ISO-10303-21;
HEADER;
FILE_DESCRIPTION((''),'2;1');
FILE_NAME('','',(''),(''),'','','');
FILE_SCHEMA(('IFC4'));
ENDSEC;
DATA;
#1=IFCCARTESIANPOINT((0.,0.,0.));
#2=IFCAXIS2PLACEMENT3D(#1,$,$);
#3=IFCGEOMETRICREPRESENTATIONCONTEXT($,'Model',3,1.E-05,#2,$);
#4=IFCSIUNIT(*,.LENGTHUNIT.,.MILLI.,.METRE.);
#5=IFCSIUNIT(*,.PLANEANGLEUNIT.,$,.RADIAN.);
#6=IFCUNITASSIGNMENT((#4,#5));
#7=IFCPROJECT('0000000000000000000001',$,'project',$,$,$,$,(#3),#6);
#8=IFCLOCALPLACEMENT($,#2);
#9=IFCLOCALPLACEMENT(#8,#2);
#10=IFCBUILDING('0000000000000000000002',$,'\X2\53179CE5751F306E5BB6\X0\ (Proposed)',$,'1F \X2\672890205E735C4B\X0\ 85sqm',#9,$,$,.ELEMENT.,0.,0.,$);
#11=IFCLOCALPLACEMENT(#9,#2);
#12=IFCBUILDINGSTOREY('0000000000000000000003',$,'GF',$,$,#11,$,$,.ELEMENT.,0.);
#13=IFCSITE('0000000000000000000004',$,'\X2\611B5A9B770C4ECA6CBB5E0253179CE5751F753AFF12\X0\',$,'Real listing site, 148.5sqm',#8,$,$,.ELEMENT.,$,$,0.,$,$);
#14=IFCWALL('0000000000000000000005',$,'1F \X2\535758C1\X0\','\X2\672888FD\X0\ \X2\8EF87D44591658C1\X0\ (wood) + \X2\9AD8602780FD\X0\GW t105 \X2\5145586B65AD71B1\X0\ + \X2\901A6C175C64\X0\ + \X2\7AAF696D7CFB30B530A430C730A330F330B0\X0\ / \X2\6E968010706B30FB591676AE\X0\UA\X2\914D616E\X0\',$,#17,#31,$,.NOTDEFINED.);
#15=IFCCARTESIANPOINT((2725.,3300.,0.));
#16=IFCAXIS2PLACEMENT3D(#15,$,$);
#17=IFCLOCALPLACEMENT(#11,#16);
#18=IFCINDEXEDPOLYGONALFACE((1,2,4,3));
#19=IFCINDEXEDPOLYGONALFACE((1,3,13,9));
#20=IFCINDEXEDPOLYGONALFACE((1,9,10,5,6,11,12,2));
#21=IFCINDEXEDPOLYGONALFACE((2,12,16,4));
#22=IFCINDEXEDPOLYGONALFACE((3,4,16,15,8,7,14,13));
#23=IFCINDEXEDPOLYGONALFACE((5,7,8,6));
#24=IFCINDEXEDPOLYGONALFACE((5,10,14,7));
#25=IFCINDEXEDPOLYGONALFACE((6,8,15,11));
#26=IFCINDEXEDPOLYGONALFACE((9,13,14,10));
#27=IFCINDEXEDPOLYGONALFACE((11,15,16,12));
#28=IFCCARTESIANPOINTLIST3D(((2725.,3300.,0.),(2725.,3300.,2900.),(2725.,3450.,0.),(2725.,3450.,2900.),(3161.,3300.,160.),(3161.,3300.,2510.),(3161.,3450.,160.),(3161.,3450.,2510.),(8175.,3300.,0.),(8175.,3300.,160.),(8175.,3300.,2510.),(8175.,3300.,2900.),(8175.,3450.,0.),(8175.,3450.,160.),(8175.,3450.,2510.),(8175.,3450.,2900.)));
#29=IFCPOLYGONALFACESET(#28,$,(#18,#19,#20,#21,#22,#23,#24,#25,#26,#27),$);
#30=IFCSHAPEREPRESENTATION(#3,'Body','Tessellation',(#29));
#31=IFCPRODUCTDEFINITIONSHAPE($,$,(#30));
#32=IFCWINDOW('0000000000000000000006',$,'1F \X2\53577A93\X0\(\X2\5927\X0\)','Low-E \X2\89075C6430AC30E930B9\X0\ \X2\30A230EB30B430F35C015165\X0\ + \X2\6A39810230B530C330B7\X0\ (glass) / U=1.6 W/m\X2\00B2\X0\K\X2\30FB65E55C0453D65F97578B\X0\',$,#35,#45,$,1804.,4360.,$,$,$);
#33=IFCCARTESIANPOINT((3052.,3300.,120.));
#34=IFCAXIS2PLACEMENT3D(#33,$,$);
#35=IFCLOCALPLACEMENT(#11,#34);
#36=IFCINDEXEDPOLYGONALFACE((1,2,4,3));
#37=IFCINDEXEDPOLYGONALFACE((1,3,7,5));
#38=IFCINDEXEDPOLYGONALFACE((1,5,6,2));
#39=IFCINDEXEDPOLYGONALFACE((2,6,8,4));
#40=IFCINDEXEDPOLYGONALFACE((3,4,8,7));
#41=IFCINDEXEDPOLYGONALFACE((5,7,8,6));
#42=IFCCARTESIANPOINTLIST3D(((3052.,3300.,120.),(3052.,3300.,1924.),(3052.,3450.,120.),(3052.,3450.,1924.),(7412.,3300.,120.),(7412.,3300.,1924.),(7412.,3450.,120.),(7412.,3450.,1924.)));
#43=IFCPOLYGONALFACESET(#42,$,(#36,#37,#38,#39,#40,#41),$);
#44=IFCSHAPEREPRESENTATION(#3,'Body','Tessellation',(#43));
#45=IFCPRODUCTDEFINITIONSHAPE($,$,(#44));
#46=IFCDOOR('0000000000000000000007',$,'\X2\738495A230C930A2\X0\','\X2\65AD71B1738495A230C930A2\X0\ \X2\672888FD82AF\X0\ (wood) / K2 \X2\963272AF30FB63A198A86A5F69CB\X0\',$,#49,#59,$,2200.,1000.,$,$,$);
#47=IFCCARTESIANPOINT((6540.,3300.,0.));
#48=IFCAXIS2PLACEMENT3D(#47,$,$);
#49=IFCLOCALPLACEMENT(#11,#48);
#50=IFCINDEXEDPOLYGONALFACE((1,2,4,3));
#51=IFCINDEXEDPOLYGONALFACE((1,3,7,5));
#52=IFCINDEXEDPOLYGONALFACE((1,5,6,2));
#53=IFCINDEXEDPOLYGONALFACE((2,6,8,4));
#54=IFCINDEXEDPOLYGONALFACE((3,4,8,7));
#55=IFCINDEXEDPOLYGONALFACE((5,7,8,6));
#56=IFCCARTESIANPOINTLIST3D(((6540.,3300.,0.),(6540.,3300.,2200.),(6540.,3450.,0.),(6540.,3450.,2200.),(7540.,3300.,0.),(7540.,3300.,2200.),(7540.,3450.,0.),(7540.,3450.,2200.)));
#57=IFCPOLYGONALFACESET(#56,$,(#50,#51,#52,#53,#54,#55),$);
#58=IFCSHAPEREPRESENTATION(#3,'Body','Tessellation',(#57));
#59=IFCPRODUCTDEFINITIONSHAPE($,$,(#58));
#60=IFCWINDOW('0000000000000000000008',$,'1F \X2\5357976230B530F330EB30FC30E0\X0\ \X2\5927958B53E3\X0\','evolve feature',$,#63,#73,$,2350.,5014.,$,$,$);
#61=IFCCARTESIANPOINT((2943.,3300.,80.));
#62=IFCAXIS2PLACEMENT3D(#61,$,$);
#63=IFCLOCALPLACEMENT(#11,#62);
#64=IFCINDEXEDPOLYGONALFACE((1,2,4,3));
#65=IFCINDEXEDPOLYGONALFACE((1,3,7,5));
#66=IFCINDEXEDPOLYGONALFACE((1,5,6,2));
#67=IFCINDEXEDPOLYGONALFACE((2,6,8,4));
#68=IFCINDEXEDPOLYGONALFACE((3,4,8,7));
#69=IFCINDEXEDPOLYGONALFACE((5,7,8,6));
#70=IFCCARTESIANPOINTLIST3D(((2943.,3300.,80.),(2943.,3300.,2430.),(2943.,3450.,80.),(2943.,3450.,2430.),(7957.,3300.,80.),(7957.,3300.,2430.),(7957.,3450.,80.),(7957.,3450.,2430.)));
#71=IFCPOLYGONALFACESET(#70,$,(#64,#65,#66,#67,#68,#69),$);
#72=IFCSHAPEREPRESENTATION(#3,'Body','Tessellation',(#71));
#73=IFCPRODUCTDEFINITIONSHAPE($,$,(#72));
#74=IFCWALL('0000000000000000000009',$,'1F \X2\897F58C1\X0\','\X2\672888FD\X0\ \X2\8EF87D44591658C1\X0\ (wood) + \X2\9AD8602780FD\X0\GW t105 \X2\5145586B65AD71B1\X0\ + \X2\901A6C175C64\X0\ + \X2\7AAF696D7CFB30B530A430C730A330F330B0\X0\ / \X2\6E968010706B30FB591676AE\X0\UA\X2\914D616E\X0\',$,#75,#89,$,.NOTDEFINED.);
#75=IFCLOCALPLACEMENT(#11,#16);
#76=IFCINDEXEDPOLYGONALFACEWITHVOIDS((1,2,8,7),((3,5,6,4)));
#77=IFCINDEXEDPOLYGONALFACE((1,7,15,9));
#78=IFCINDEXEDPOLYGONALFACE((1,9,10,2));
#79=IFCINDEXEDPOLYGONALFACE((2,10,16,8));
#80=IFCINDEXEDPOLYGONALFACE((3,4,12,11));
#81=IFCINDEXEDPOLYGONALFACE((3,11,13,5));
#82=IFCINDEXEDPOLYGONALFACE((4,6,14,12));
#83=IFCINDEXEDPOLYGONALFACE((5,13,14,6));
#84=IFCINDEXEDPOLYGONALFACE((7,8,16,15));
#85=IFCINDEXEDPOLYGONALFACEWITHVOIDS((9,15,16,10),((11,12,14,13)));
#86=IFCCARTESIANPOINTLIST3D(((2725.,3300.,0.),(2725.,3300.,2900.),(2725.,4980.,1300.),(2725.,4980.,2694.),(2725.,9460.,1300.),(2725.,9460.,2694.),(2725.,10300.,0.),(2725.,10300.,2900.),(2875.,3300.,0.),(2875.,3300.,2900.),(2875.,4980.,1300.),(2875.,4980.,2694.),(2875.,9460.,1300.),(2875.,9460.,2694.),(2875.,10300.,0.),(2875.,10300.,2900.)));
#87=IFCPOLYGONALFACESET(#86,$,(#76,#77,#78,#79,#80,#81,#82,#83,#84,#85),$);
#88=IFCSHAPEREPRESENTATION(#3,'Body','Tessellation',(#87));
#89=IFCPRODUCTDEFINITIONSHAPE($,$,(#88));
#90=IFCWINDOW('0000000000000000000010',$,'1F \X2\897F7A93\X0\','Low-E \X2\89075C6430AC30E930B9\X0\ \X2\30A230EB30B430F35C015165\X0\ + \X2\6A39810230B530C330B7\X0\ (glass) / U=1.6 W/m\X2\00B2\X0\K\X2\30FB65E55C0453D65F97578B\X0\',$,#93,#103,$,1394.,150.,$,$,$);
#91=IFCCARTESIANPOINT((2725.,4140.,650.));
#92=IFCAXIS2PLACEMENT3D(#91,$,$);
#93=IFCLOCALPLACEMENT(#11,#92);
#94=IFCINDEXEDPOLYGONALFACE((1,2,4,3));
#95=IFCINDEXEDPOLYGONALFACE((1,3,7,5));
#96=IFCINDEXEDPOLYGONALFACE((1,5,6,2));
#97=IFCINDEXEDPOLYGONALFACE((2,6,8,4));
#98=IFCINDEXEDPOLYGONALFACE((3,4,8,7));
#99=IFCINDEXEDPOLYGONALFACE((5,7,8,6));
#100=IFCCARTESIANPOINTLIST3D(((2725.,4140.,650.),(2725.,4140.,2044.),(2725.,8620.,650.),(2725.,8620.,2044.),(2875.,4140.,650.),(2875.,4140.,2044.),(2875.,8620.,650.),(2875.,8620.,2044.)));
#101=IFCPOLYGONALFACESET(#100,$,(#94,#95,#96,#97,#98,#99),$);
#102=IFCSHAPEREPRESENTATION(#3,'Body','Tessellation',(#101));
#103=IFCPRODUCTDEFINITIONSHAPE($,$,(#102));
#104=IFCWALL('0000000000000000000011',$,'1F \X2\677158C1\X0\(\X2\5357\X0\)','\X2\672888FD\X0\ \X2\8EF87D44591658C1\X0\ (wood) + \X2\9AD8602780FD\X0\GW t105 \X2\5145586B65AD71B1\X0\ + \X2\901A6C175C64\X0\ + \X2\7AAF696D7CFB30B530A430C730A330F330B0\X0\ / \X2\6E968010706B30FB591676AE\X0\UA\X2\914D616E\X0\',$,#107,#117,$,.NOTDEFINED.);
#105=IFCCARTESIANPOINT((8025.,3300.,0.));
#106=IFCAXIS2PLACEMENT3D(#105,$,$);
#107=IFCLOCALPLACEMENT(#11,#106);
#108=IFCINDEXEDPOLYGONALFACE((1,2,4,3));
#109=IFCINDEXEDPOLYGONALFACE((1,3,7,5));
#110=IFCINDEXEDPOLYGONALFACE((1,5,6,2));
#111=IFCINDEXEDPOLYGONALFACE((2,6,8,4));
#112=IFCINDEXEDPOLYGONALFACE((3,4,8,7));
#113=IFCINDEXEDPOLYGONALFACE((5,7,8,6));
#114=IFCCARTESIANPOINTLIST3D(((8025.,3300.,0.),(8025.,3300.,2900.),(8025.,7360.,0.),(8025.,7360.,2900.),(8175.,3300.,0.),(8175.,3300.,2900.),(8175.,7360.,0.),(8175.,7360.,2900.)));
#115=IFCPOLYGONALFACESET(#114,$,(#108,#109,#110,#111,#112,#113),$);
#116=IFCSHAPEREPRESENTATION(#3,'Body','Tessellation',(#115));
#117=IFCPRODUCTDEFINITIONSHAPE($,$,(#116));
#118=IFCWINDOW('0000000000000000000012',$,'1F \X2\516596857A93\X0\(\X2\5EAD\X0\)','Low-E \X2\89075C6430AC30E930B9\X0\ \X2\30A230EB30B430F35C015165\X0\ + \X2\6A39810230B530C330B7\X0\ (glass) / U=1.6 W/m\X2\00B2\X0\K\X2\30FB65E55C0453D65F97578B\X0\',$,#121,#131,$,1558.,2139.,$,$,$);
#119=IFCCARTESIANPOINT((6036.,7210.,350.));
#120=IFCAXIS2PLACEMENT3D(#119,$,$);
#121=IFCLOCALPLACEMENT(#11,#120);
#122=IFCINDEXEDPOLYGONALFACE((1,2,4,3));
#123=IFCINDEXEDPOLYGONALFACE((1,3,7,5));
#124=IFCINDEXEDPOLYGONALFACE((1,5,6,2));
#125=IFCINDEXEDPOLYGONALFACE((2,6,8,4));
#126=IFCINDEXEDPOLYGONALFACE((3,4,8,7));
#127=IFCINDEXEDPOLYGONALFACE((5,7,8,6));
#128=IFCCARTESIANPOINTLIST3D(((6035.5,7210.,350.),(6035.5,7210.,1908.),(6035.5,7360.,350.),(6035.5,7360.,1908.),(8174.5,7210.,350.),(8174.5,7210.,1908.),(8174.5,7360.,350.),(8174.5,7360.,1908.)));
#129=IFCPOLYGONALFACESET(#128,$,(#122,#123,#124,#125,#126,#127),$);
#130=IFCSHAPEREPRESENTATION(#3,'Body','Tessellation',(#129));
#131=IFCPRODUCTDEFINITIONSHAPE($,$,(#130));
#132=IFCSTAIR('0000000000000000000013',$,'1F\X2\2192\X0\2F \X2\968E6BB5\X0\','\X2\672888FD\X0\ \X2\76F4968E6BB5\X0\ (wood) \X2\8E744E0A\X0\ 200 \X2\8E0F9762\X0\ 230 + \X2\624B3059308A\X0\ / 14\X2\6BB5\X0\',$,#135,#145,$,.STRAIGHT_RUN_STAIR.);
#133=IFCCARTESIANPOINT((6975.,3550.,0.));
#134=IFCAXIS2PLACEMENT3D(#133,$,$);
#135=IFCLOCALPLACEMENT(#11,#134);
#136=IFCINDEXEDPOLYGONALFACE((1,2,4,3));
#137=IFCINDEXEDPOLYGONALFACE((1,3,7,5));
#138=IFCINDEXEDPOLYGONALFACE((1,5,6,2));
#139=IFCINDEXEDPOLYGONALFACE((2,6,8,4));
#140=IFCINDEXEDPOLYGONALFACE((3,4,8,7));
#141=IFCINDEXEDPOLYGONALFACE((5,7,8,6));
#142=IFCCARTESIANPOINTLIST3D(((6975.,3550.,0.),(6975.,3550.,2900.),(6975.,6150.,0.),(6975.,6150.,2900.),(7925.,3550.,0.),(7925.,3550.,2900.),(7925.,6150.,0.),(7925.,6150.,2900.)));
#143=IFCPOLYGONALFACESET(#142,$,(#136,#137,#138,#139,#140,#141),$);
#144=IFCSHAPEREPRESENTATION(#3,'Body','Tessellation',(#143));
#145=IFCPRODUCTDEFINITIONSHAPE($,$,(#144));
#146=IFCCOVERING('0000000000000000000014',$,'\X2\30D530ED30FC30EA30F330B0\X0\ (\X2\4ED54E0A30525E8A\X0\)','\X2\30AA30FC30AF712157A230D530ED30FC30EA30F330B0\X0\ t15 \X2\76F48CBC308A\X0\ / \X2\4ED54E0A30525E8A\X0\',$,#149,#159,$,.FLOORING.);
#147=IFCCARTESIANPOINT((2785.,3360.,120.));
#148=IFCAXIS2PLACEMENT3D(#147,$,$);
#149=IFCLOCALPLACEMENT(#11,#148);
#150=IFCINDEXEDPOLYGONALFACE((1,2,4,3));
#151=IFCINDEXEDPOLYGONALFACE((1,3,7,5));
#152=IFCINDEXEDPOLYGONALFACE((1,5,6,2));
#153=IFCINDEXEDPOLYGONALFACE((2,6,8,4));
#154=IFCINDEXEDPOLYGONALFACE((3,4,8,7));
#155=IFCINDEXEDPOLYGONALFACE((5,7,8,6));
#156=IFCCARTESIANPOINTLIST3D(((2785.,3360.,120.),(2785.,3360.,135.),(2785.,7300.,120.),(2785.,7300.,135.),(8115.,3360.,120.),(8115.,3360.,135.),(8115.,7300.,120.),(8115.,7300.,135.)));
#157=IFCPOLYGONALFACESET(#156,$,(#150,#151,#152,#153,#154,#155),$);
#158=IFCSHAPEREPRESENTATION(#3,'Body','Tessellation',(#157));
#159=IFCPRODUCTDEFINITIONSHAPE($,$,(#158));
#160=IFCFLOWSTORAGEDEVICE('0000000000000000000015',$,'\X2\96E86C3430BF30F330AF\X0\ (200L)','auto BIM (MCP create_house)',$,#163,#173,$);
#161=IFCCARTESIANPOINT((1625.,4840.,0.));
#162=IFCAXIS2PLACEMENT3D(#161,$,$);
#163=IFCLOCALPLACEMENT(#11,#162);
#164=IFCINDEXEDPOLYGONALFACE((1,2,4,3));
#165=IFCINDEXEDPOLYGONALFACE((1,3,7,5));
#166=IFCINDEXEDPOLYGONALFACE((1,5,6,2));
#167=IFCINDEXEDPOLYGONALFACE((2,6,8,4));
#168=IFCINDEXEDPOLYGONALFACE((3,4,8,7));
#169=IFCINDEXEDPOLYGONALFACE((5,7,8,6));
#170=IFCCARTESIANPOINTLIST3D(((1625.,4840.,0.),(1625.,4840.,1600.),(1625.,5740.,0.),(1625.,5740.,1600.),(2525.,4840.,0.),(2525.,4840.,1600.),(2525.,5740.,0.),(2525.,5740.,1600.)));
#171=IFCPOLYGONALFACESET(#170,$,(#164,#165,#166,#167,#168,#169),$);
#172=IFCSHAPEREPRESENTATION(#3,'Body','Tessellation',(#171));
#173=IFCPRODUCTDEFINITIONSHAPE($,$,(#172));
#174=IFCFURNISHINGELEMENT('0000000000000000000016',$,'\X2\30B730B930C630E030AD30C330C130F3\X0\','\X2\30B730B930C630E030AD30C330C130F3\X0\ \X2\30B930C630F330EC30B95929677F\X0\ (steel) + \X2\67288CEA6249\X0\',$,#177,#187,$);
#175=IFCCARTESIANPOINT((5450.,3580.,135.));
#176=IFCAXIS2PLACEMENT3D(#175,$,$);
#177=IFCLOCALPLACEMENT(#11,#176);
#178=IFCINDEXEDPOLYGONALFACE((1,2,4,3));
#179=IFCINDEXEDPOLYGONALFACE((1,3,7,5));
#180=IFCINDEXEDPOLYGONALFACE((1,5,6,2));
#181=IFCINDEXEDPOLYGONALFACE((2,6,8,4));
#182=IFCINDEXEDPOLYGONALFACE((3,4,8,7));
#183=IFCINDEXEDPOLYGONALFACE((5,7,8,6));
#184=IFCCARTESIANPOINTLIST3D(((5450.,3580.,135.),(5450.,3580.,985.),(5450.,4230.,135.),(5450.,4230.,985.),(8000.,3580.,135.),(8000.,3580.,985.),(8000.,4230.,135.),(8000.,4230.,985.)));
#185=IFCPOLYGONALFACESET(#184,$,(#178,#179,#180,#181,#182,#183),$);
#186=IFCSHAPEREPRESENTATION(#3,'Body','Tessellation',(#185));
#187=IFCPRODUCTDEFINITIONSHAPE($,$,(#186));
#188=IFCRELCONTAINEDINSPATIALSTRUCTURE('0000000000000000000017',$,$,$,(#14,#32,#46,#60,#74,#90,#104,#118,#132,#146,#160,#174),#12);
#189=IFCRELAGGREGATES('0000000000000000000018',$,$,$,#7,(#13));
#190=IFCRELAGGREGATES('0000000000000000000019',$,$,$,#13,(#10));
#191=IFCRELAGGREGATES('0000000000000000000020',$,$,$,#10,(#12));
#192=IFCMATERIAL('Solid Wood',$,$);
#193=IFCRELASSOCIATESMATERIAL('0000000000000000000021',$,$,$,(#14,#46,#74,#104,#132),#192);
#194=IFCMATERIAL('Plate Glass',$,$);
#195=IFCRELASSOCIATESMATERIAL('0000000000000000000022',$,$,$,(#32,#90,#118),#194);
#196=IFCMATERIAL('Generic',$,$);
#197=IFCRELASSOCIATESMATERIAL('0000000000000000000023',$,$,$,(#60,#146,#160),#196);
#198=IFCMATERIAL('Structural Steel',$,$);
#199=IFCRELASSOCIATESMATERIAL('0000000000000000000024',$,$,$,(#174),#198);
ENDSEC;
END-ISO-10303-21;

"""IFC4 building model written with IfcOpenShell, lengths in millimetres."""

from ifc_helpers import new_model, si_unit, frame, frame_2d, origin, place, context, project, spatial, rectangle, extrude, material, element, fill, save


model = new_model("IFC4")

# Units and contexts
model_context = context("Model", 3, precision=1e-05, world=origin())
ifc_project = project(units=[si_unit("LENGTHUNIT", "METRE", prefix="MILLI"), si_unit("PLANEANGLEUNIT", "RADIAN")], contexts=[model_context])

# Site, building, storey
site_placement = place(None, origin())
site = spatial("IfcSite", under=ifc_project, at=site_placement, Name="愛媛県今治市北鳥生町２", ObjectType="Real listing site, 148.5sqm", CompositionType="ELEMENT", RefElevation=0.0)
building_placement = place(site_placement, origin())
building = spatial("IfcBuilding", under=site, at=building_placement, Name="北鳥生の家 (Proposed)", ObjectType="1F 木造平屋 85sqm", CompositionType="ELEMENT", ElevationOfRefHeight=0.0, ElevationOfTerrain=0.0)
storey_placement = place(building_placement, origin())
storey = spatial("IfcBuildingStorey", under=building, at=storey_placement, Name="GF", CompositionType="ELEMENT", Elevation=0.0)

# Shared definitions
ifc_material_1 = material(Name="Solid Wood")
ifc_material_2 = material(Name="Generic")

# Wall, openings, windows, door
wall_1_placement = place(storey_placement, frame((2725.0, 3300.0, 0.0)))
wall_1 = element("IfcWall", 1, at=wall_1_placement, inside=storey, material=ifc_material_1, Name="1F 南壁", Description="木製 軸組外壁 (wood) + 高性能GW t105 充填断熱 + 通気層 + 窯業系サイディング / 準耐火・外皮UA配慮", PredefinedType="NOTDEFINED", context=model_context, shape_type="SweptSolid", body=[
    extrude(rectangle(XDim=5450.0, YDim=150.0, at=frame_2d((2725.0, 75.0))), frame((2725.0, 3300.0, 0.0)), (0.0, 0.0, 1.0), 2900.0),
])
opening_1_placement = place(storey_placement, frame((3052.0, 3300.0, 120.0)))
opening_1 = element("IfcOpeningElement", 2, at=opening_1_placement, cuts=wall_1, PredefinedType="NOTDEFINED", context=model_context, shape_type="SweptSolid", body=[
    extrude(rectangle(XDim=4360.0, YDim=150.0, at=frame_2d((2180.0, 75.0))), frame((3052.0, 3300.0, 120.0)), (0.0, 0.0, 1.0), 1804.0),
])
opening_2_placement = place(storey_placement, frame((6540.0, 3300.0, 0.0)))
opening_2 = element("IfcOpeningElement", 3, at=opening_2_placement, cuts=wall_1, PredefinedType="NOTDEFINED", context=model_context, shape_type="SweptSolid", body=[
    extrude(rectangle(XDim=1000.0, YDim=150.0, at=frame_2d((500.0, 75.0))), frame((6540.0, 3300.0, 0.0)), (0.0, 0.0, 1.0), 2200.0),
])
opening_3_placement = place(storey_placement, frame((2943.0, 3300.0, 80.0)))
opening_3 = element("IfcOpeningElement", 4, at=opening_3_placement, cuts=wall_1, PredefinedType="NOTDEFINED", context=model_context, shape_type="SweptSolid", body=[
    extrude(rectangle(XDim=5014.0, YDim=150.0, at=frame_2d((2507.0, 75.0))), frame((2943.0, 3300.0, 80.0)), (0.0, 0.0, 1.0), 2350.0),
])
ifc_material_3 = material(Name="Plate Glass")
window_1_placement = place(storey_placement, frame((3052.0, 3300.0, 120.0)))
window_1 = element("IfcWindow", 5, at=window_1_placement, inside=storey, material=ifc_material_3, Name="1F 南窓(大)", Description="Low-E 複層ガラス アルゴン封入 + 樹脂サッシ (glass) / U=1.6 W/m²K・日射取得型", OverallHeight=1804.0, OverallWidth=4360.0, context=model_context, shape_type="SweptSolid", body=[
    extrude(rectangle(XDim=4360.0, YDim=150.0, at=frame_2d((2180.0, 75.0))), frame((3052.0, 3300.0, 120.0)), (0.0, 0.0, 1.0), 1804.0),
])
fill(opening_1, window_1)
door_1_placement = place(storey_placement, frame((6540.0, 3300.0, 0.0)))
door_1 = element("IfcDoor", 6, at=door_1_placement, inside=storey, material=ifc_material_1, Name="玄関ドア", Description="断熱玄関ドア 木製芯 (wood) / K2 防犯・採風機構", OverallHeight=2200.0, OverallWidth=1000.0, context=model_context, shape_type="SweptSolid", body=[
    extrude(rectangle(XDim=1000.0, YDim=150.0, at=frame_2d((500.0, 75.0))), frame((6540.0, 3300.0, 0.0)), (0.0, 0.0, 1.0), 2200.0),
])
fill(opening_2, door_1)
window_2_placement = place(storey_placement, frame((2943.0, 3300.0, 80.0)))
window_2 = element("IfcWindow", 7, at=window_2_placement, inside=storey, material=ifc_material_2, Name="1F 南面サンルーム 大開口", Description="evolve feature", OverallHeight=2350.0, OverallWidth=5014.0, context=model_context, shape_type="SweptSolid", body=[
    extrude(rectangle(XDim=5014.0, YDim=150.0, at=frame_2d((2507.0, 75.0))), frame((2943.0, 3300.0, 80.0)), (0.0, 0.0, 1.0), 2350.0),
])
fill(opening_3, window_2)

# Walls, openings, windows
wall_2_placement = place(storey_placement, frame((2725.0, 3300.0, 0.0)))
wall_2 = element("IfcWall", 8, at=wall_2_placement, inside=storey, material=ifc_material_1, Name="1F 西壁", Description="木製 軸組外壁 (wood) + 高性能GW t105 充填断熱 + 通気層 + 窯業系サイディング / 準耐火・外皮UA配慮", PredefinedType="NOTDEFINED", context=model_context, shape_type="SweptSolid", body=[
    extrude(rectangle(XDim=150.0, YDim=7000.0, at=frame_2d((75.0, 3500.0))), frame((2725.0, 3300.0, 0.0)), (0.0, 0.0, 1.0), 2900.0),
])
opening_4_placement = place(storey_placement, frame((2725.0, 4140.0, 650.0)))
opening_4 = element("IfcOpeningElement", 9, at=opening_4_placement, cuts=wall_2, PredefinedType="NOTDEFINED", context=model_context, shape_type="SweptSolid", body=[
    extrude(rectangle(XDim=150.0, YDim=4480.0, at=frame_2d((75.0, 2240.0))), frame((2725.0, 4140.0, 650.0)), (0.0, 0.0, 1.0), 1394.0),
])
window_3_placement = place(storey_placement, frame((2725.0, 4140.0, 650.0)))
window_3 = element("IfcWindow", 10, at=window_3_placement, inside=storey, material=ifc_material_3, Name="1F 西窓", Description="Low-E 複層ガラス アルゴン封入 + 樹脂サッシ (glass) / U=1.6 W/m²K・日射取得型", OverallHeight=1394.0, OverallWidth=150.0, context=model_context, shape_type="SweptSolid", body=[
    extrude(rectangle(XDim=150.0, YDim=4480.0, at=frame_2d((75.0, 2240.0))), frame((2725.0, 4140.0, 650.0)), (0.0, 0.0, 1.0), 1394.0),
])
fill(opening_4, window_3)
wall_3_placement = place(storey_placement, frame((8025.0, 3300.0, 0.0)))
wall_3 = element("IfcWall", 11, at=wall_3_placement, inside=storey, material=ifc_material_1, Name="1F 東壁(南)", Description="木製 軸組外壁 (wood) + 高性能GW t105 充填断熱 + 通気層 + 窯業系サイディング / 準耐火・外皮UA配慮", PredefinedType="NOTDEFINED", context=model_context, shape_type="SweptSolid", body=[
    extrude(rectangle(XDim=150.0, YDim=4060.0, at=frame_2d((75.0, 2030.0))), frame((8025.0, 3300.0, 0.0)), (0.0, 0.0, 1.0), 2900.0),
])
opening_5_placement = place(storey_placement, frame((6036.0, 7210.0, 350.0)))
opening_5 = element("IfcOpeningElement", 12, at=opening_5_placement, cuts=wall_3, PredefinedType="NOTDEFINED", context=model_context, shape_type="SweptSolid", body=[
    extrude(rectangle(XDim=2139.0, YDim=150.0, at=frame_2d((1069.0, 75.0))), frame((6036.0, 7210.0, 350.0)), (0.0, 0.0, 1.0), 1558.0),
])
window_4_placement = place(storey_placement, frame((6036.0, 7210.0, 350.0)))
window_4 = element("IfcWindow", 13, at=window_4_placement, inside=storey, material=ifc_material_3, Name="1F 入隅窓(庭)", Description="Low-E 複層ガラス アルゴン封入 + 樹脂サッシ (glass) / U=1.6 W/m²K・日射取得型", OverallHeight=1558.0, OverallWidth=2139.0, context=model_context, shape_type="SweptSolid", body=[
    extrude(rectangle(XDim=2139.0, YDim=150.0, at=frame_2d((1069.0, 75.0))), frame((6036.0, 7210.0, 350.0)), (0.0, 0.0, 1.0), 1558.0),
])
fill(opening_5, window_4)

# Stair
stair_placement = place(storey_placement, frame((6975.0, 3550.0, 0.0)))
element("IfcStair", 14, at=stair_placement, inside=storey, material=ifc_material_1, Name="1F→2F 階段", Description="木製 直階段 (wood) 蹴上 200 踏面 230 + 手すり / 14段", PredefinedType="STRAIGHT_RUN_STAIR", context=model_context, shape_type="SweptSolid", body=[
    extrude(rectangle(XDim=950.0, YDim=2600.0, at=frame_2d((475.0, 1300.0))), frame((6975.0, 3550.0, 0.0)), (0.0, 0.0, 1.0), 2900.0),
])

# Covering
covering_placement = place(storey_placement, frame((2785.0, 3360.0, 120.0)))
element("IfcCovering", 15, at=covering_placement, inside=storey, material=ifc_material_2, Name="フローリング (仕上げ床)", Description="オーク無垢フローリング t15 直貼り / 仕上げ床", PredefinedType="FLOORING", context=model_context, shape_type="SweptSolid", body=[
    extrude(rectangle(XDim=5330.0, YDim=3940.0, at=frame_2d((2665.0, 1970.0))), frame((2785.0, 3360.0, 120.0)), (0.0, 0.0, 1.0), 15.0),
])

# Flow storage device
flow_storage_device_placement = place(storey_placement, frame((1625.0, 4840.0, 0.0)))
element("IfcFlowStorageDevice", 16, at=flow_storage_device_placement, inside=storey, material=ifc_material_2, Name="雨水タンク (200L)", Description="auto BIM (MCP create_house)", context=model_context, shape_type="SweptSolid", body=[
    extrude(rectangle(XDim=900.0, YDim=900.0, at=frame_2d((450.0, 450.0))), frame((1625.0, 4840.0, 0.0)), (0.0, 0.0, 1.0), 1600.0),
])

# Furnishing element
ifc_material_4 = material(Name="Structural Steel")
furnishing_placement = place(storey_placement, frame((5450.0, 3580.0, 135.0)))
element("IfcFurnishingElement", 17, at=furnishing_placement, inside=storey, material=ifc_material_4, Name="システムキッチン", Description="システムキッチン ステンレス天板 (steel) + 木質扉", context=model_context, shape_type="SweptSolid", body=[
    extrude(rectangle(XDim=2550.0, YDim=650.0, at=frame_2d((1275.0, 325.0))), frame((5450.0, 3580.0, 135.0)), (0.0, 0.0, 1.0), 850.0),
])

save(model, "model.ifc")
